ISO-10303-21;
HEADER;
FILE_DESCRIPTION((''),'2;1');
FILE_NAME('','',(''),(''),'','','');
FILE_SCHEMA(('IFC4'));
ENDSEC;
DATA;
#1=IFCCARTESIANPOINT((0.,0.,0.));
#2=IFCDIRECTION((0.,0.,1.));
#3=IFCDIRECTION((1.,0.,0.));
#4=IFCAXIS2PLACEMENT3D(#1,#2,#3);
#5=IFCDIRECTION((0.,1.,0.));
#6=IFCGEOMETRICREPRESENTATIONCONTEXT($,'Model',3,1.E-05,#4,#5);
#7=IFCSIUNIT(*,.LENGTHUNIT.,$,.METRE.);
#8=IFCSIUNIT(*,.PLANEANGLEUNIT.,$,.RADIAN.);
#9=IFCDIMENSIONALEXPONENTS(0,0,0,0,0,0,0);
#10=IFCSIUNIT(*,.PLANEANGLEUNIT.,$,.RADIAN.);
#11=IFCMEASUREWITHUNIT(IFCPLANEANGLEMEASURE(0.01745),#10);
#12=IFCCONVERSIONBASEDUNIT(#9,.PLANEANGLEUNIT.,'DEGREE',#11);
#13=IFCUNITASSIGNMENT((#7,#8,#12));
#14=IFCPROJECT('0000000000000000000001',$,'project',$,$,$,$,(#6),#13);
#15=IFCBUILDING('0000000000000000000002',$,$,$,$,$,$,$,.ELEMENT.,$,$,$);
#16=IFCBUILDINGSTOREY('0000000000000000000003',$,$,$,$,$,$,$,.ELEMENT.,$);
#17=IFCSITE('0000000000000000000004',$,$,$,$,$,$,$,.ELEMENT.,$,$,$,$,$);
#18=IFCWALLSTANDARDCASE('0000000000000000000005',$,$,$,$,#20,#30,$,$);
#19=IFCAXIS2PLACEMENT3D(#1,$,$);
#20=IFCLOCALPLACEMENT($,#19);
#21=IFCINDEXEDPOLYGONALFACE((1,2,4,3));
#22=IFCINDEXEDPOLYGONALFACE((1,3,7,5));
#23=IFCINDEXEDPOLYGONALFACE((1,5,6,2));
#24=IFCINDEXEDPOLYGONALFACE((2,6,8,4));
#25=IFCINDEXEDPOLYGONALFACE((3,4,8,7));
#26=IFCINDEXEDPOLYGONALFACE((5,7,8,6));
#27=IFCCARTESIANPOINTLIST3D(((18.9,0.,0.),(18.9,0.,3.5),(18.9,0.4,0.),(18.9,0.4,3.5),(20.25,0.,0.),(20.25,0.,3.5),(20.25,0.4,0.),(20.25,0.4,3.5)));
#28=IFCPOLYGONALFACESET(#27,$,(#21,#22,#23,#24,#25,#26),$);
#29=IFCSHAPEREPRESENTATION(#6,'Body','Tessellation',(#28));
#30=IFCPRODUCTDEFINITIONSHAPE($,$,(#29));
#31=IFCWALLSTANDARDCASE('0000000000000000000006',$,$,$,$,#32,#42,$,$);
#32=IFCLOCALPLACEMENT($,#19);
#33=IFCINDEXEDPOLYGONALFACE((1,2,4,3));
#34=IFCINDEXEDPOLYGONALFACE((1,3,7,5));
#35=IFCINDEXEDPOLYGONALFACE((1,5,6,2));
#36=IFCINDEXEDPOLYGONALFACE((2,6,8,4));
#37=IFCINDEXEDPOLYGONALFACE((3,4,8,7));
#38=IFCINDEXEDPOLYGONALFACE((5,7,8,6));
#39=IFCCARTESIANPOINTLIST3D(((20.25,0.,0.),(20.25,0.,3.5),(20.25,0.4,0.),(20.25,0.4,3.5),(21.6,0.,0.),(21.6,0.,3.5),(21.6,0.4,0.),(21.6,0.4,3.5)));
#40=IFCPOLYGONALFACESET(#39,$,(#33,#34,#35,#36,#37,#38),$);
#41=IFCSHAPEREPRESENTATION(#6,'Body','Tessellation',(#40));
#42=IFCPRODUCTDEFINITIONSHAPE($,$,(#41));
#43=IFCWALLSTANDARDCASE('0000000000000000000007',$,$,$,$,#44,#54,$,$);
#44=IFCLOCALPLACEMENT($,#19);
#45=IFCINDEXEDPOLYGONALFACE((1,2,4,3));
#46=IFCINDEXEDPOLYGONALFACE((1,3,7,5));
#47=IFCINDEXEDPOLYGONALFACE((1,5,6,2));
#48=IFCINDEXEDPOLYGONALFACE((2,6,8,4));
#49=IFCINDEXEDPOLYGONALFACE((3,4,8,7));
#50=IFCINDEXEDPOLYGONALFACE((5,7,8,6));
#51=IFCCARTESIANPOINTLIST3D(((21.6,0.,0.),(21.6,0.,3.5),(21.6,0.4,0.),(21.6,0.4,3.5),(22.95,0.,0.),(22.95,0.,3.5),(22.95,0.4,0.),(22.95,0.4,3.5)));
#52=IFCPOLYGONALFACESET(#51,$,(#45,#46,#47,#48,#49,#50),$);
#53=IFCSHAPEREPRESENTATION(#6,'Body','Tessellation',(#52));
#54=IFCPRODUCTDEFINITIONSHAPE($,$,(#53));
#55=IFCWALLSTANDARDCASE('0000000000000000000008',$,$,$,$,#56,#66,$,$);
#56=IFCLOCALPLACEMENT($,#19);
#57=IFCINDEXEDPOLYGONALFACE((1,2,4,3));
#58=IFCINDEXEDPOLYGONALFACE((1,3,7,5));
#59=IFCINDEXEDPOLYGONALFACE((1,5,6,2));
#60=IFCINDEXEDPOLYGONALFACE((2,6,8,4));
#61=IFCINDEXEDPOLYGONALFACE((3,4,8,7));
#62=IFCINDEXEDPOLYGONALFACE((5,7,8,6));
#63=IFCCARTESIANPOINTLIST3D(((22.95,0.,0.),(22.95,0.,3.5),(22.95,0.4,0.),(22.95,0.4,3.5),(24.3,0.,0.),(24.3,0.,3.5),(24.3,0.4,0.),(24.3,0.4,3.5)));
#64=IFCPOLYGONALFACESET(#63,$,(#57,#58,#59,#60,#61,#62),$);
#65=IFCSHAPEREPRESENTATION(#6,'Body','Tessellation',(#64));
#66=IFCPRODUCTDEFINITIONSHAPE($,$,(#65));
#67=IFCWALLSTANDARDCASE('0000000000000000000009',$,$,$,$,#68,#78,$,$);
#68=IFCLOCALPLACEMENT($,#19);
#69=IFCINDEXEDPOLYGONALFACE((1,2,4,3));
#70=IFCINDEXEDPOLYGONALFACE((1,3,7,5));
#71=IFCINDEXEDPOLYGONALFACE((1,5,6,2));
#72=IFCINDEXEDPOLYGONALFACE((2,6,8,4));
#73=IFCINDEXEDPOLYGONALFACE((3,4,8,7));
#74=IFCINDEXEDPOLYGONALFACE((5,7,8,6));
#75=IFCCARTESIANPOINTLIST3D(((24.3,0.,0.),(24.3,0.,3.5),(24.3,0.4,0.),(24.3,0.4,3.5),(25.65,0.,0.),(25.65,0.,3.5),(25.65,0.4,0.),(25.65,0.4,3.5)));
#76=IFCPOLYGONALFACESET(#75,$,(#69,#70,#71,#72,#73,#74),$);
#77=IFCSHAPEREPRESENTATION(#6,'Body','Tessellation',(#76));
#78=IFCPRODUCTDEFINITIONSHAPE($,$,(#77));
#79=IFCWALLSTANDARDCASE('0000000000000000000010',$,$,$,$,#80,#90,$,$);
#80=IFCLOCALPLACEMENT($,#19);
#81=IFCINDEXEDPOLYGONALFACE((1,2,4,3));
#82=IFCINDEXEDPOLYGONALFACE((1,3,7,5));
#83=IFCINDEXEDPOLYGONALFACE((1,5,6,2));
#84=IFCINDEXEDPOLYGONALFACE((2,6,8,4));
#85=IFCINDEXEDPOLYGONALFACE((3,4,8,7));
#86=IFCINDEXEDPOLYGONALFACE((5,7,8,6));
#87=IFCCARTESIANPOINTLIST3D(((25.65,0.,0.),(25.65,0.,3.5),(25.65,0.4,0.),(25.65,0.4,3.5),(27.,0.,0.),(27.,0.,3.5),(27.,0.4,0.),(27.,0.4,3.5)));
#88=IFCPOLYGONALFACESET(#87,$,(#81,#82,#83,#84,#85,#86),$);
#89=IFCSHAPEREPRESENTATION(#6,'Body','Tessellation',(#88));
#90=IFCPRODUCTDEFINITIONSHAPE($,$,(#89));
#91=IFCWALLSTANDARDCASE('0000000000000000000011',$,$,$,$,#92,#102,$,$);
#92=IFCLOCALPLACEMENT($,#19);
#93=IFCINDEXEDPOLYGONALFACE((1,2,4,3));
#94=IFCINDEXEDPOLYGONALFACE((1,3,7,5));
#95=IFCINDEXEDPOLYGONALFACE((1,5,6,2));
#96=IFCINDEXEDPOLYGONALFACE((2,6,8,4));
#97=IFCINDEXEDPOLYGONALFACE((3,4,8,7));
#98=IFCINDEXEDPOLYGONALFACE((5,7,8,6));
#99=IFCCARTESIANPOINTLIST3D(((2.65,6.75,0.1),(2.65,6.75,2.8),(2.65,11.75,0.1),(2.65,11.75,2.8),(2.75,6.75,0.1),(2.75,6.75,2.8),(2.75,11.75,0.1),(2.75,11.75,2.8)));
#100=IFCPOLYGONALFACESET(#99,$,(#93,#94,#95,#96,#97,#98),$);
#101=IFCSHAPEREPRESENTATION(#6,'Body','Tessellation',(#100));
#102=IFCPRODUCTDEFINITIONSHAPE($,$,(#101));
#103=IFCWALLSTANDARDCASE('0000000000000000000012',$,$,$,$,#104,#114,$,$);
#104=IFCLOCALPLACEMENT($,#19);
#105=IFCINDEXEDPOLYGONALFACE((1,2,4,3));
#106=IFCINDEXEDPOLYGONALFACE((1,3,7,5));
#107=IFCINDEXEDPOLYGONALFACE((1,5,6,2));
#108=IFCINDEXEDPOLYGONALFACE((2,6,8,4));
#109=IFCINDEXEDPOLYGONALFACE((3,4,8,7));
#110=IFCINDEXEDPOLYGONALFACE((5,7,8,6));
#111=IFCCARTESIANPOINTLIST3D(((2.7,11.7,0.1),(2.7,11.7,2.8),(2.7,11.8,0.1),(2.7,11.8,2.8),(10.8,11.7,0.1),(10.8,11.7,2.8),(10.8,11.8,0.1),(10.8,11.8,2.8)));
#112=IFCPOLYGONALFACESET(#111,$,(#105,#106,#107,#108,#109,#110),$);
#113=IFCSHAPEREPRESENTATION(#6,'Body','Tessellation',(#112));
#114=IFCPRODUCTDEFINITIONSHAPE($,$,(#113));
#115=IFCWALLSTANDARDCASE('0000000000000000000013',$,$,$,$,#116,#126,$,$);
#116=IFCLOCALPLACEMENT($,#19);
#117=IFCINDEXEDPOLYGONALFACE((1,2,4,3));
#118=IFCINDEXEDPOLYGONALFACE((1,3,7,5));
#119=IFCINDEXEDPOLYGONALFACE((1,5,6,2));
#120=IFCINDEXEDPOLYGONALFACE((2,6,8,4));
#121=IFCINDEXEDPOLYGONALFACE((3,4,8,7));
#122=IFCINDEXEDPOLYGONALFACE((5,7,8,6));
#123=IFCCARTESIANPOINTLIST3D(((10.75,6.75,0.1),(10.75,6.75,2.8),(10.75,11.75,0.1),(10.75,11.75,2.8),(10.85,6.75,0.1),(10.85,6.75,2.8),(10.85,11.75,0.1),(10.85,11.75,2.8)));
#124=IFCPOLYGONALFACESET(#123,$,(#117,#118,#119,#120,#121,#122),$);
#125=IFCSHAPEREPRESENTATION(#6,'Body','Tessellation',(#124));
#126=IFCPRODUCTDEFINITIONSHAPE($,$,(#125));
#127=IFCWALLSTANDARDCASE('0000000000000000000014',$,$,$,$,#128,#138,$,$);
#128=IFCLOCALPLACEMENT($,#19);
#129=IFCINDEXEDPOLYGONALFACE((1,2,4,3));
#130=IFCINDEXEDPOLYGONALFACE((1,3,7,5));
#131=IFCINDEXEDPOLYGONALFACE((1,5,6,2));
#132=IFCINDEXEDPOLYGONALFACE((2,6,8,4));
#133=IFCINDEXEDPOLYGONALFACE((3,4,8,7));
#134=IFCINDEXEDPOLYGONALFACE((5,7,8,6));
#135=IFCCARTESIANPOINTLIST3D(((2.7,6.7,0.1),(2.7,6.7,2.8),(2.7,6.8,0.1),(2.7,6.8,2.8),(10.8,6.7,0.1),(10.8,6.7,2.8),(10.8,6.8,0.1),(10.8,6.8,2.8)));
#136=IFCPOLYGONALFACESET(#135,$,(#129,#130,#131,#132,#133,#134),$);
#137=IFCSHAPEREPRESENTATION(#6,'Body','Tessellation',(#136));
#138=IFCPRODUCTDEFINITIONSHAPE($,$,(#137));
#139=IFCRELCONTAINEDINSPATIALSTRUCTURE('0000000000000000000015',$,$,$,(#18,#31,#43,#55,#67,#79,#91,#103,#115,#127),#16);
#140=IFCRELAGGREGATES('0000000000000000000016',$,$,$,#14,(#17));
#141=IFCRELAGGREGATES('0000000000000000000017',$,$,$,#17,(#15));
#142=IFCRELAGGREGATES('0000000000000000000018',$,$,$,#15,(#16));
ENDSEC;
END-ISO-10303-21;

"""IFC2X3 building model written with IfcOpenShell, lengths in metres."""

from ifc_helpers import new_model, entity, si_unit, converted_unit, direction, origin_with_axes, place, context, project, spatial, polyline, outline, extrude, element, save


model = new_model("IFC2X3")

# Units and contexts
model_context = context("Model", 3, precision=1e-05, world=origin_with_axes(), true_north=direction((0.0, 1.0, 0.0)))
ifc_project = project(units=[si_unit("LENGTHUNIT", "METRE"), si_unit("PLANEANGLEUNIT", "RADIAN"), converted_unit("PLANEANGLEUNIT", "DEGREE", entity("IfcPlaneAngleMeasure", 0.01745), si_unit("PLANEANGLEUNIT", "RADIAN"), dimensions=[0, 0, 0, 0, 0, 0, 0])], contexts=[model_context])

# Site, building, storey
site = spatial("IfcSite", under=ifc_project, CompositionType="ELEMENT")
building = spatial("IfcBuilding", under=site, CompositionType="ELEMENT")
storey = spatial("IfcBuildingStorey", under=building, CompositionType="ELEMENT")

# Walls
wall_1_placement = place(None, origin_with_axes())
element("IfcWallStandardCase", 1, at=wall_1_placement, inside=storey, context=model_context, shape_type="SweptSolid", body=[
    extrude(outline(polyline([(18.9, 0.0, 0.0), (20.25, 0.0, 0.0), (20.25, 0.4, 0.0), (18.9, 0.4, 0.0)])), origin_with_axes(), (0.0, 0.0, 1.0), 3.5),
])
wall_2_placement = place(None, origin_with_axes())
element("IfcWallStandardCase", 2, at=wall_2_placement, inside=storey, context=model_context, shape_type="SweptSolid", body=[
    extrude(outline(polyline([(20.25, 0.0, 0.0), (21.6, 0.0, 0.0), (21.6, 0.4, 0.0), (20.25, 0.4, 0.0)])), origin_with_axes(), (0.0, 0.0, 1.0), 3.5),
])
wall_3_placement = place(None, origin_with_axes())
element("IfcWallStandardCase", 3, at=wall_3_placement, inside=storey, context=model_context, shape_type="SweptSolid", body=[
    extrude(outline(polyline([(21.6, 0.0, 0.0), (22.95, 0.0, 0.0), (22.95, 0.4, 0.0), (21.6, 0.4, 0.0)])), origin_with_axes(), (0.0, 0.0, 1.0), 3.5),
])
wall_4_placement = place(None, origin_with_axes())
element("IfcWallStandardCase", 4, at=wall_4_placement, inside=storey, context=model_context, shape_type="SweptSolid", body=[
    extrude(outline(polyline([(22.95, 0.0, 0.0), (24.3, 0.0, 0.0), (24.3, 0.4, 0.0), (22.95, 0.4, 0.0)])), origin_with_axes(), (0.0, 0.0, 1.0), 3.5),
])
wall_5_placement = place(None, origin_with_axes())
element("IfcWallStandardCase", 5, at=wall_5_placement, inside=storey, context=model_context, shape_type="SweptSolid", body=[
    extrude(outline(polyline([(24.3, 0.0, 0.0), (25.65, 0.0, 0.0), (25.65, 0.4, 0.0), (24.3, 0.4, 0.0)])), origin_with_axes(), (0.0, 0.0, 1.0), 3.5),
])
wall_6_placement = place(None, origin_with_axes())
element("IfcWallStandardCase", 6, at=wall_6_placement, inside=storey, context=model_context, shape_type="SweptSolid", body=[
    extrude(outline(polyline([(25.65, 0.0, 0.0), (27.0, 0.0, 0.0), (27.0, 0.4, 0.0), (25.65, 0.4, 0.0)])), origin_with_axes(), (0.0, 0.0, 1.0), 3.5),
])
wall_7_placement = place(None, origin_with_axes())
element("IfcWallStandardCase", 7, at=wall_7_placement, inside=storey, context=model_context, shape_type="SweptSolid", body=[
    extrude(outline(polyline([(2.75, 6.75, 0.1), (2.75, 11.75, 0.1), (2.65, 11.75, 0.1), (2.65, 6.75, 0.1)])), origin_with_axes(), (0.0, 0.0, 1.0), 2.7),
])
wall_8_placement = place(None, origin_with_axes())
element("IfcWallStandardCase", 8, at=wall_8_placement, inside=storey, context=model_context, shape_type="SweptSolid", body=[
    extrude(outline(polyline([(2.7, 11.7, 0.1), (10.8, 11.7, 0.1), (10.8, 11.8, 0.1), (2.7, 11.8, 0.1)])), origin_with_axes(), (0.0, 0.0, 1.0), 2.7),
])
wall_9_placement = place(None, origin_with_axes())
element("IfcWallStandardCase", 9, at=wall_9_placement, inside=storey, context=model_context, shape_type="SweptSolid", body=[
    extrude(outline(polyline([(10.75, 11.75, 0.1), (10.75, 6.75, 0.1), (10.85, 6.75, 0.1), (10.85, 11.75, 0.1)])), origin_with_axes(), (0.0, 0.0, 1.0), 2.7),
])
wall_10_placement = place(None, origin_with_axes())
element("IfcWallStandardCase", 10, at=wall_10_placement, inside=storey, context=model_context, shape_type="SweptSolid", body=[
    extrude(outline(polyline([(10.8, 6.8, 0.1), (2.7, 6.8, 0.1), (2.7, 6.7, 0.1), (10.8, 6.7, 0.1)])), origin_with_axes(), (0.0, 0.0, 1.0), 2.7),
])

save(model, "model.ifc")
